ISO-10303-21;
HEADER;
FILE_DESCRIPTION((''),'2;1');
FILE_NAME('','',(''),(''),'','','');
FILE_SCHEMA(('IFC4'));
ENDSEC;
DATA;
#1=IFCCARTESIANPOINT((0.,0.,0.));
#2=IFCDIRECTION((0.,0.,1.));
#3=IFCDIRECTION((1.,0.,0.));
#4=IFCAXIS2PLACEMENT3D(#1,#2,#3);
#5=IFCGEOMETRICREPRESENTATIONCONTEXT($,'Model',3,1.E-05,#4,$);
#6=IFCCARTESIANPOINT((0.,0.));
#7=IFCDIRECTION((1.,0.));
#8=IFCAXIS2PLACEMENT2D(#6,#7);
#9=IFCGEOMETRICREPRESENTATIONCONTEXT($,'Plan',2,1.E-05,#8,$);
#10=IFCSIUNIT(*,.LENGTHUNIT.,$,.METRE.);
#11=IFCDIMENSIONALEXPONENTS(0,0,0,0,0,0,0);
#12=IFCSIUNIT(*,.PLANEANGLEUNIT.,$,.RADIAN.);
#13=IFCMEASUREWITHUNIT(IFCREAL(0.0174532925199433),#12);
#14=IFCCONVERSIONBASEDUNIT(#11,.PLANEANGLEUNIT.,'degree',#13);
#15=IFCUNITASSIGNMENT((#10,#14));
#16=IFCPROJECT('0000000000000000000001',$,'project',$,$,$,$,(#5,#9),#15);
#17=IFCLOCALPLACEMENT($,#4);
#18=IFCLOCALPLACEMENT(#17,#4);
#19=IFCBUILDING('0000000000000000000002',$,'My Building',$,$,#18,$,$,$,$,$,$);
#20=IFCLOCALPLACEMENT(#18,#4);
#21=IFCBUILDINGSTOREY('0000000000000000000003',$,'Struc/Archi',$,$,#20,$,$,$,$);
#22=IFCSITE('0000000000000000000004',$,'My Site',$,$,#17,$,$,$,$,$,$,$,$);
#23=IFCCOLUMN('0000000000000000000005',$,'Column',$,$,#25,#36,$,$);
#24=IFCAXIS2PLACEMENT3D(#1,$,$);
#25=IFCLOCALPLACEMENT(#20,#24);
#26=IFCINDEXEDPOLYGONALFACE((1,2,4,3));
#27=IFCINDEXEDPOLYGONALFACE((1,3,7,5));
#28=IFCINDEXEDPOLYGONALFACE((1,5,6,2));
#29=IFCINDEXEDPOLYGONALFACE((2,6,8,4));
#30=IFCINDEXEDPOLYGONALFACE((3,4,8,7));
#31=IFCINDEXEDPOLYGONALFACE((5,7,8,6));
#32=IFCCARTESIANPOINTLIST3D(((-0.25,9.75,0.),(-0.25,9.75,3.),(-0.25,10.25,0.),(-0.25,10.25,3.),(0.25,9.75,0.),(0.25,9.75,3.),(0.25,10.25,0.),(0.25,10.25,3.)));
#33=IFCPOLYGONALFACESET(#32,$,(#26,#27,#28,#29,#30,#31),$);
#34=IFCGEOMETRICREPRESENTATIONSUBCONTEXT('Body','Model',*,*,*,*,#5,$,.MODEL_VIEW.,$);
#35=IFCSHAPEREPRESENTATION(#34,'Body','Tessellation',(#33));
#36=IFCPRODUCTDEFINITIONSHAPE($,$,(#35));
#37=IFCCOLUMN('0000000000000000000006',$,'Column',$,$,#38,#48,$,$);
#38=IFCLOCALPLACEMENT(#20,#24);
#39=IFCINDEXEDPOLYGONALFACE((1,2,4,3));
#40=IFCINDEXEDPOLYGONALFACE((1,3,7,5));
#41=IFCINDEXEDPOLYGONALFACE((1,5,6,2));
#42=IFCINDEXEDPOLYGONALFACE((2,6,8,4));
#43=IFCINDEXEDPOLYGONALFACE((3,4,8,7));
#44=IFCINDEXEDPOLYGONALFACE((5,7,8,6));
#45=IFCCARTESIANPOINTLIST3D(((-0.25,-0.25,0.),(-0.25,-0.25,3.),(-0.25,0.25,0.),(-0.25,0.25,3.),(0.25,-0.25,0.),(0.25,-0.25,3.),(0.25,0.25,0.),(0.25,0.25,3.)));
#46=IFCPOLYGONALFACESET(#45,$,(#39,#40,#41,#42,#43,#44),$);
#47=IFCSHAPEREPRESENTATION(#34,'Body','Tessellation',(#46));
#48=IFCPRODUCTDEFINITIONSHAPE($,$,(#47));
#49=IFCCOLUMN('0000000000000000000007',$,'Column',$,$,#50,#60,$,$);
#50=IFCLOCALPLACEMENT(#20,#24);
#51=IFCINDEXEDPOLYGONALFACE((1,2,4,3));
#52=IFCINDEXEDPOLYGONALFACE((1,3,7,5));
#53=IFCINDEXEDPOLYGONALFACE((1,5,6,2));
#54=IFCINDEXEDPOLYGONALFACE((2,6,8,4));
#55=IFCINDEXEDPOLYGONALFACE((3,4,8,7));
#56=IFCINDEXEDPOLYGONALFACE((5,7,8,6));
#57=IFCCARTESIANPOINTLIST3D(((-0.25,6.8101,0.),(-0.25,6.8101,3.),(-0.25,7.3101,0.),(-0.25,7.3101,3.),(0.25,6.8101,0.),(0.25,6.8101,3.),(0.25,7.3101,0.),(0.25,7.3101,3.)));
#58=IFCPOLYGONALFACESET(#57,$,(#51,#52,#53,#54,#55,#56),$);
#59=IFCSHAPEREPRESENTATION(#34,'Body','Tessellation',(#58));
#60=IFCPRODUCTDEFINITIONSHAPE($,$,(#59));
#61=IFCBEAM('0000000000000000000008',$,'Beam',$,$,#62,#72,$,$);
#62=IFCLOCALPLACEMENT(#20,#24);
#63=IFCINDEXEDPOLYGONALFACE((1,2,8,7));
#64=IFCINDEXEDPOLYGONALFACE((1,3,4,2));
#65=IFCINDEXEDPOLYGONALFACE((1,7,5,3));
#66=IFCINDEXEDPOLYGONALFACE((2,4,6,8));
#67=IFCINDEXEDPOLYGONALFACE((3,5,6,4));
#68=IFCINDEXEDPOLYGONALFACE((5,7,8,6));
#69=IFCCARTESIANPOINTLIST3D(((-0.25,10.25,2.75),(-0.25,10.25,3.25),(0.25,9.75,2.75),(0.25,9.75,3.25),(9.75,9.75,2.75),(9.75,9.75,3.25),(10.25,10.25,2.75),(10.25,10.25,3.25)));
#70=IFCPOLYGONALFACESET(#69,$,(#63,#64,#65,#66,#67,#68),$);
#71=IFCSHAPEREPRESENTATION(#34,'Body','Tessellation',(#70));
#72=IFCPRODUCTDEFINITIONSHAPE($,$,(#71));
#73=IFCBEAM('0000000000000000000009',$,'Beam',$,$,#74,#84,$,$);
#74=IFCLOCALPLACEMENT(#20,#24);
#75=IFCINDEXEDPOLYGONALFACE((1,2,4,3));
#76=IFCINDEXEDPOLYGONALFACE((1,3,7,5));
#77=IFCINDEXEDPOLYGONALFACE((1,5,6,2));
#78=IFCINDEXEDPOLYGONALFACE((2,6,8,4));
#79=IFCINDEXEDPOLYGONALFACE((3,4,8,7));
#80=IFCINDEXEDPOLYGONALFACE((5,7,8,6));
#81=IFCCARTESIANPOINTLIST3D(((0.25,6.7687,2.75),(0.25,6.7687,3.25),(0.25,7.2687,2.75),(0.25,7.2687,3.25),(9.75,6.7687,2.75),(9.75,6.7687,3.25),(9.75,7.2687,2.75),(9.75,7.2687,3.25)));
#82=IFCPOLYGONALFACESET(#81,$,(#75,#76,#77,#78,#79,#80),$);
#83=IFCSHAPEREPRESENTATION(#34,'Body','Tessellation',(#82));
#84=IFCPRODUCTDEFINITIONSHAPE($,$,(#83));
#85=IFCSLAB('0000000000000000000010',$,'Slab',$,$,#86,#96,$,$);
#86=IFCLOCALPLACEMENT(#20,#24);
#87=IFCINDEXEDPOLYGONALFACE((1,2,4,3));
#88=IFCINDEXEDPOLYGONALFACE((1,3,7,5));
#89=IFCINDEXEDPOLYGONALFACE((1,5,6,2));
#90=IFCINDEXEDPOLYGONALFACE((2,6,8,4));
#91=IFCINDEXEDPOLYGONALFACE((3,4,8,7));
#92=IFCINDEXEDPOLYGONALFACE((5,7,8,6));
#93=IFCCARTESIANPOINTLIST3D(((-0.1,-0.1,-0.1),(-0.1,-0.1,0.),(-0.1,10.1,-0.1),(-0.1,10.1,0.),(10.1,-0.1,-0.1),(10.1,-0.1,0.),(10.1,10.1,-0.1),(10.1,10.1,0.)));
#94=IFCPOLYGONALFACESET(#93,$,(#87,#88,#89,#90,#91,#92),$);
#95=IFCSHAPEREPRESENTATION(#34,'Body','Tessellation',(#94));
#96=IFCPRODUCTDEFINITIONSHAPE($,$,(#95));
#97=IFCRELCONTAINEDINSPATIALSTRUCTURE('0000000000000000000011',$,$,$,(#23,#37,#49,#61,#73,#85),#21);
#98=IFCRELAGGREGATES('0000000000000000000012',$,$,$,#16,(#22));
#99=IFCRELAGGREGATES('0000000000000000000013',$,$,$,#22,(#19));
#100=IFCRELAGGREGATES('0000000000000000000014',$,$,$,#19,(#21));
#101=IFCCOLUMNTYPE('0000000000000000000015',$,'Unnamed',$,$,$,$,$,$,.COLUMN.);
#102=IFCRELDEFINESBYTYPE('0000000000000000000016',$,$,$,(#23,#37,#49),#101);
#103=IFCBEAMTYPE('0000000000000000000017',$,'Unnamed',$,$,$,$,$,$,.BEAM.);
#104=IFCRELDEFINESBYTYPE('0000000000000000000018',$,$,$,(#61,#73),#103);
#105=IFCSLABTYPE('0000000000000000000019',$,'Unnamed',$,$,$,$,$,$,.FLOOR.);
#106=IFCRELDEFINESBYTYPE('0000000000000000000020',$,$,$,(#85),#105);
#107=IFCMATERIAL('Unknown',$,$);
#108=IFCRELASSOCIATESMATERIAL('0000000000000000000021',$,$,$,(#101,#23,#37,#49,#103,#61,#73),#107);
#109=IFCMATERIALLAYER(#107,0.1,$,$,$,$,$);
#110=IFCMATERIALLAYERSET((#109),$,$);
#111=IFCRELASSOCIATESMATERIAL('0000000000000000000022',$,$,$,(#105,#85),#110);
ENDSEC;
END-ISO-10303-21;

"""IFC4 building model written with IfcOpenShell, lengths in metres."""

from ifc_helpers import new_model, entity, si_unit, converted_unit, frame, origin_with_axes, origin_2d_with_axis, place, context, subcontext, project, spatial, indexed_curve, rectangle, outline, extrude, clip, halfspace, material, layer, layer_set, layer_usage, material_profile, profile_set, profile_usage, type_object, element, save


model = new_model("IFC4")

# Units and contexts
model_context = context("Model", 3, precision=1e-05, world=origin_with_axes())
plan_context = context("Plan", 2, precision=1e-05, world=origin_2d_with_axis())
body_context_1 = subcontext(model_context, "Body", "Model", "MODEL_VIEW")
ifc_project = project(units=[si_unit("LENGTHUNIT", "METRE"), converted_unit("PLANEANGLEUNIT", "degree", entity("IfcReal", 0.0174532925199433), si_unit("PLANEANGLEUNIT", "RADIAN"), dimensions=[0, 0, 0, 0, 0, 0, 0])], contexts=[model_context, plan_context])

# Site, building, storey
site_placement = place(None, origin_with_axes())
site = spatial("IfcSite", under=ifc_project, at=site_placement, Name="My Site")
building_placement = place(site_placement, origin_with_axes())
building = spatial("IfcBuilding", under=site, at=building_placement, Name="My Building")
storey_placement = place(building_placement, origin_with_axes())
storey = spatial("IfcBuildingStorey", under=building, at=storey_placement, Name="Struc/Archi")

# Columns
ifc_material = material(Name="Unknown")
ifc_material_profile_1 = material_profile(ifc_material, rectangle(XDim=0.5, YDim=0.5))
ifc_profile_set_1 = profile_set([ifc_material_profile_1])
ifc_profile_usage_1 = profile_usage(ifc_profile_set_1, cardinal=5)
column_type = type_object("IfcColumnType", Name="Unnamed", PredefinedType="COLUMN", material=ifc_profile_set_1)
column_1_placement = place(storey_placement, frame((0.0, 10.0, 0.0), z_axis=(0.0, 0.0, 1.0), x_axis=(1.0, 0.0, 0.0)))
element("IfcColumn", 1, at=column_1_placement, inside=storey, type_object=column_type, material=ifc_profile_usage_1, Name="Column", context=body_context_1, shape_type="SweptSolid", body=[
    extrude(rectangle(XDim=0.5, YDim=0.5), origin_with_axes(), (0.0, 0.0, 1.0), 3.0),
])
ifc_profile_usage_2 = profile_usage(ifc_profile_set_1, cardinal=5)
column_2_placement = place(storey_placement, frame((0.0, 0.0, 0.0), z_axis=(0.0, 0.0, 1.0), x_axis=(1.0, 0.0, 0.0)))
element("IfcColumn", 2, at=column_2_placement, inside=storey, type_object=column_type, material=ifc_profile_usage_2, Name="Column", context=body_context_1, shape_type="SweptSolid", body=[
    extrude(rectangle(XDim=0.5, YDim=0.5), origin_with_axes(), (0.0, 0.0, 1.0), 3.0),
])
ifc_profile_usage_3 = profile_usage(ifc_profile_set_1, cardinal=5)
column_3_placement = place(storey_placement, frame((0.0, 7.0601, 0.0), z_axis=(0.0, 0.0, 1.0), x_axis=(1.0, 0.0, 0.0)))
element("IfcColumn", 3, at=column_3_placement, inside=storey, type_object=column_type, material=ifc_profile_usage_3, Name="Column", context=body_context_1, shape_type="SweptSolid", body=[
    extrude(rectangle(XDim=0.5, YDim=0.5), origin_with_axes(), (0.0, 0.0, 1.0), 3.0),
])

# Beams
ifc_material_profile_2 = material_profile(ifc_material, rectangle(XDim=0.5, YDim=0.5))
ifc_profile_set_2 = profile_set([ifc_material_profile_2])
ifc_profile_usage_4 = profile_usage(ifc_profile_set_2, cardinal=5)
beam_type = type_object("IfcBeamType", Name="Unnamed", PredefinedType="BEAM", material=ifc_profile_set_2)
beam_1_placement = place(storey_placement, frame((-0.25, 10.0, 3.0), z_axis=(1.0, 0.0, 0.0), x_axis=(0.0, 1.0, 0.0)))
element("IfcBeam", 4, at=beam_1_placement, inside=storey, type_object=beam_type, material=ifc_profile_usage_4, Name="Beam", context=body_context_1, shape_type="Clipping", body=[
    clip(clip(extrude(rectangle(XDim=0.5, YDim=0.5), origin_with_axes(), (0.0, 0.0, 1.0), 10.5), halfspace(frame((0.25, -3.0, 10.5), z_axis=(-0.707107, 0.0, 0.707107), x_axis=(0.0, 1.0, 0.0)), False)), halfspace(frame((0.25, -3.0, 0.0), z_axis=(-0.707107, 0.0, -0.707107), x_axis=(0.0, 1.0, 0.0)), False)),
])
ifc_profile_usage_5 = profile_usage(ifc_profile_set_2, cardinal=5)
beam_2_placement = place(storey_placement, frame((0.25, 7.0187, 3.0), z_axis=(1.0, 0.0, 0.0), x_axis=(0.0, 1.0, 0.0)))
element("IfcBeam", 5, at=beam_2_placement, inside=storey, type_object=beam_type, material=ifc_profile_usage_5, Name="Beam", context=body_context_1, shape_type="SweptSolid", body=[
    extrude(rectangle(XDim=0.5, YDim=0.5), origin_with_axes(), (0.0, 0.0, 1.0), 9.5),
])

# Slab
ifc_layer_1 = layer(ifc_material, 0.1)
ifc_layer_set_1 = layer_set([ifc_layer_1])
ifc_layer_usage_1 = layer_usage(ifc_layer_set_1, "AXIS3", "POSITIVE", -0.1)
slab_type = type_object("IfcSlabType", Name="Unnamed", PredefinedType="FLOOR", material=ifc_layer_set_1)
slab_placement = place(storey_placement, frame((-0.1, 10.1, 0.0), z_axis=(0.0, 0.0, 1.0), x_axis=(1.0, 0.0, 0.0)))
element("IfcSlab", 6, at=slab_placement, inside=storey, type_object=slab_type, material=ifc_layer_usage_1, Name="Slab", context=body_context_1, shape_type="SweptSolid", body=[
    extrude(outline(indexed_curve([(0.0, 0.0), (10.2, 0.0), (10.2, -10.2), (0.0, -10.2), (0.0, 0.0)])), frame((0.0, 0.0, -0.1), z_axis=(0.0, 0.0, 1.0), x_axis=(1.0, 0.0, 0.0)), (0.0, 0.0, 1.0), 0.1),
])

save(model, "model.ifc")
